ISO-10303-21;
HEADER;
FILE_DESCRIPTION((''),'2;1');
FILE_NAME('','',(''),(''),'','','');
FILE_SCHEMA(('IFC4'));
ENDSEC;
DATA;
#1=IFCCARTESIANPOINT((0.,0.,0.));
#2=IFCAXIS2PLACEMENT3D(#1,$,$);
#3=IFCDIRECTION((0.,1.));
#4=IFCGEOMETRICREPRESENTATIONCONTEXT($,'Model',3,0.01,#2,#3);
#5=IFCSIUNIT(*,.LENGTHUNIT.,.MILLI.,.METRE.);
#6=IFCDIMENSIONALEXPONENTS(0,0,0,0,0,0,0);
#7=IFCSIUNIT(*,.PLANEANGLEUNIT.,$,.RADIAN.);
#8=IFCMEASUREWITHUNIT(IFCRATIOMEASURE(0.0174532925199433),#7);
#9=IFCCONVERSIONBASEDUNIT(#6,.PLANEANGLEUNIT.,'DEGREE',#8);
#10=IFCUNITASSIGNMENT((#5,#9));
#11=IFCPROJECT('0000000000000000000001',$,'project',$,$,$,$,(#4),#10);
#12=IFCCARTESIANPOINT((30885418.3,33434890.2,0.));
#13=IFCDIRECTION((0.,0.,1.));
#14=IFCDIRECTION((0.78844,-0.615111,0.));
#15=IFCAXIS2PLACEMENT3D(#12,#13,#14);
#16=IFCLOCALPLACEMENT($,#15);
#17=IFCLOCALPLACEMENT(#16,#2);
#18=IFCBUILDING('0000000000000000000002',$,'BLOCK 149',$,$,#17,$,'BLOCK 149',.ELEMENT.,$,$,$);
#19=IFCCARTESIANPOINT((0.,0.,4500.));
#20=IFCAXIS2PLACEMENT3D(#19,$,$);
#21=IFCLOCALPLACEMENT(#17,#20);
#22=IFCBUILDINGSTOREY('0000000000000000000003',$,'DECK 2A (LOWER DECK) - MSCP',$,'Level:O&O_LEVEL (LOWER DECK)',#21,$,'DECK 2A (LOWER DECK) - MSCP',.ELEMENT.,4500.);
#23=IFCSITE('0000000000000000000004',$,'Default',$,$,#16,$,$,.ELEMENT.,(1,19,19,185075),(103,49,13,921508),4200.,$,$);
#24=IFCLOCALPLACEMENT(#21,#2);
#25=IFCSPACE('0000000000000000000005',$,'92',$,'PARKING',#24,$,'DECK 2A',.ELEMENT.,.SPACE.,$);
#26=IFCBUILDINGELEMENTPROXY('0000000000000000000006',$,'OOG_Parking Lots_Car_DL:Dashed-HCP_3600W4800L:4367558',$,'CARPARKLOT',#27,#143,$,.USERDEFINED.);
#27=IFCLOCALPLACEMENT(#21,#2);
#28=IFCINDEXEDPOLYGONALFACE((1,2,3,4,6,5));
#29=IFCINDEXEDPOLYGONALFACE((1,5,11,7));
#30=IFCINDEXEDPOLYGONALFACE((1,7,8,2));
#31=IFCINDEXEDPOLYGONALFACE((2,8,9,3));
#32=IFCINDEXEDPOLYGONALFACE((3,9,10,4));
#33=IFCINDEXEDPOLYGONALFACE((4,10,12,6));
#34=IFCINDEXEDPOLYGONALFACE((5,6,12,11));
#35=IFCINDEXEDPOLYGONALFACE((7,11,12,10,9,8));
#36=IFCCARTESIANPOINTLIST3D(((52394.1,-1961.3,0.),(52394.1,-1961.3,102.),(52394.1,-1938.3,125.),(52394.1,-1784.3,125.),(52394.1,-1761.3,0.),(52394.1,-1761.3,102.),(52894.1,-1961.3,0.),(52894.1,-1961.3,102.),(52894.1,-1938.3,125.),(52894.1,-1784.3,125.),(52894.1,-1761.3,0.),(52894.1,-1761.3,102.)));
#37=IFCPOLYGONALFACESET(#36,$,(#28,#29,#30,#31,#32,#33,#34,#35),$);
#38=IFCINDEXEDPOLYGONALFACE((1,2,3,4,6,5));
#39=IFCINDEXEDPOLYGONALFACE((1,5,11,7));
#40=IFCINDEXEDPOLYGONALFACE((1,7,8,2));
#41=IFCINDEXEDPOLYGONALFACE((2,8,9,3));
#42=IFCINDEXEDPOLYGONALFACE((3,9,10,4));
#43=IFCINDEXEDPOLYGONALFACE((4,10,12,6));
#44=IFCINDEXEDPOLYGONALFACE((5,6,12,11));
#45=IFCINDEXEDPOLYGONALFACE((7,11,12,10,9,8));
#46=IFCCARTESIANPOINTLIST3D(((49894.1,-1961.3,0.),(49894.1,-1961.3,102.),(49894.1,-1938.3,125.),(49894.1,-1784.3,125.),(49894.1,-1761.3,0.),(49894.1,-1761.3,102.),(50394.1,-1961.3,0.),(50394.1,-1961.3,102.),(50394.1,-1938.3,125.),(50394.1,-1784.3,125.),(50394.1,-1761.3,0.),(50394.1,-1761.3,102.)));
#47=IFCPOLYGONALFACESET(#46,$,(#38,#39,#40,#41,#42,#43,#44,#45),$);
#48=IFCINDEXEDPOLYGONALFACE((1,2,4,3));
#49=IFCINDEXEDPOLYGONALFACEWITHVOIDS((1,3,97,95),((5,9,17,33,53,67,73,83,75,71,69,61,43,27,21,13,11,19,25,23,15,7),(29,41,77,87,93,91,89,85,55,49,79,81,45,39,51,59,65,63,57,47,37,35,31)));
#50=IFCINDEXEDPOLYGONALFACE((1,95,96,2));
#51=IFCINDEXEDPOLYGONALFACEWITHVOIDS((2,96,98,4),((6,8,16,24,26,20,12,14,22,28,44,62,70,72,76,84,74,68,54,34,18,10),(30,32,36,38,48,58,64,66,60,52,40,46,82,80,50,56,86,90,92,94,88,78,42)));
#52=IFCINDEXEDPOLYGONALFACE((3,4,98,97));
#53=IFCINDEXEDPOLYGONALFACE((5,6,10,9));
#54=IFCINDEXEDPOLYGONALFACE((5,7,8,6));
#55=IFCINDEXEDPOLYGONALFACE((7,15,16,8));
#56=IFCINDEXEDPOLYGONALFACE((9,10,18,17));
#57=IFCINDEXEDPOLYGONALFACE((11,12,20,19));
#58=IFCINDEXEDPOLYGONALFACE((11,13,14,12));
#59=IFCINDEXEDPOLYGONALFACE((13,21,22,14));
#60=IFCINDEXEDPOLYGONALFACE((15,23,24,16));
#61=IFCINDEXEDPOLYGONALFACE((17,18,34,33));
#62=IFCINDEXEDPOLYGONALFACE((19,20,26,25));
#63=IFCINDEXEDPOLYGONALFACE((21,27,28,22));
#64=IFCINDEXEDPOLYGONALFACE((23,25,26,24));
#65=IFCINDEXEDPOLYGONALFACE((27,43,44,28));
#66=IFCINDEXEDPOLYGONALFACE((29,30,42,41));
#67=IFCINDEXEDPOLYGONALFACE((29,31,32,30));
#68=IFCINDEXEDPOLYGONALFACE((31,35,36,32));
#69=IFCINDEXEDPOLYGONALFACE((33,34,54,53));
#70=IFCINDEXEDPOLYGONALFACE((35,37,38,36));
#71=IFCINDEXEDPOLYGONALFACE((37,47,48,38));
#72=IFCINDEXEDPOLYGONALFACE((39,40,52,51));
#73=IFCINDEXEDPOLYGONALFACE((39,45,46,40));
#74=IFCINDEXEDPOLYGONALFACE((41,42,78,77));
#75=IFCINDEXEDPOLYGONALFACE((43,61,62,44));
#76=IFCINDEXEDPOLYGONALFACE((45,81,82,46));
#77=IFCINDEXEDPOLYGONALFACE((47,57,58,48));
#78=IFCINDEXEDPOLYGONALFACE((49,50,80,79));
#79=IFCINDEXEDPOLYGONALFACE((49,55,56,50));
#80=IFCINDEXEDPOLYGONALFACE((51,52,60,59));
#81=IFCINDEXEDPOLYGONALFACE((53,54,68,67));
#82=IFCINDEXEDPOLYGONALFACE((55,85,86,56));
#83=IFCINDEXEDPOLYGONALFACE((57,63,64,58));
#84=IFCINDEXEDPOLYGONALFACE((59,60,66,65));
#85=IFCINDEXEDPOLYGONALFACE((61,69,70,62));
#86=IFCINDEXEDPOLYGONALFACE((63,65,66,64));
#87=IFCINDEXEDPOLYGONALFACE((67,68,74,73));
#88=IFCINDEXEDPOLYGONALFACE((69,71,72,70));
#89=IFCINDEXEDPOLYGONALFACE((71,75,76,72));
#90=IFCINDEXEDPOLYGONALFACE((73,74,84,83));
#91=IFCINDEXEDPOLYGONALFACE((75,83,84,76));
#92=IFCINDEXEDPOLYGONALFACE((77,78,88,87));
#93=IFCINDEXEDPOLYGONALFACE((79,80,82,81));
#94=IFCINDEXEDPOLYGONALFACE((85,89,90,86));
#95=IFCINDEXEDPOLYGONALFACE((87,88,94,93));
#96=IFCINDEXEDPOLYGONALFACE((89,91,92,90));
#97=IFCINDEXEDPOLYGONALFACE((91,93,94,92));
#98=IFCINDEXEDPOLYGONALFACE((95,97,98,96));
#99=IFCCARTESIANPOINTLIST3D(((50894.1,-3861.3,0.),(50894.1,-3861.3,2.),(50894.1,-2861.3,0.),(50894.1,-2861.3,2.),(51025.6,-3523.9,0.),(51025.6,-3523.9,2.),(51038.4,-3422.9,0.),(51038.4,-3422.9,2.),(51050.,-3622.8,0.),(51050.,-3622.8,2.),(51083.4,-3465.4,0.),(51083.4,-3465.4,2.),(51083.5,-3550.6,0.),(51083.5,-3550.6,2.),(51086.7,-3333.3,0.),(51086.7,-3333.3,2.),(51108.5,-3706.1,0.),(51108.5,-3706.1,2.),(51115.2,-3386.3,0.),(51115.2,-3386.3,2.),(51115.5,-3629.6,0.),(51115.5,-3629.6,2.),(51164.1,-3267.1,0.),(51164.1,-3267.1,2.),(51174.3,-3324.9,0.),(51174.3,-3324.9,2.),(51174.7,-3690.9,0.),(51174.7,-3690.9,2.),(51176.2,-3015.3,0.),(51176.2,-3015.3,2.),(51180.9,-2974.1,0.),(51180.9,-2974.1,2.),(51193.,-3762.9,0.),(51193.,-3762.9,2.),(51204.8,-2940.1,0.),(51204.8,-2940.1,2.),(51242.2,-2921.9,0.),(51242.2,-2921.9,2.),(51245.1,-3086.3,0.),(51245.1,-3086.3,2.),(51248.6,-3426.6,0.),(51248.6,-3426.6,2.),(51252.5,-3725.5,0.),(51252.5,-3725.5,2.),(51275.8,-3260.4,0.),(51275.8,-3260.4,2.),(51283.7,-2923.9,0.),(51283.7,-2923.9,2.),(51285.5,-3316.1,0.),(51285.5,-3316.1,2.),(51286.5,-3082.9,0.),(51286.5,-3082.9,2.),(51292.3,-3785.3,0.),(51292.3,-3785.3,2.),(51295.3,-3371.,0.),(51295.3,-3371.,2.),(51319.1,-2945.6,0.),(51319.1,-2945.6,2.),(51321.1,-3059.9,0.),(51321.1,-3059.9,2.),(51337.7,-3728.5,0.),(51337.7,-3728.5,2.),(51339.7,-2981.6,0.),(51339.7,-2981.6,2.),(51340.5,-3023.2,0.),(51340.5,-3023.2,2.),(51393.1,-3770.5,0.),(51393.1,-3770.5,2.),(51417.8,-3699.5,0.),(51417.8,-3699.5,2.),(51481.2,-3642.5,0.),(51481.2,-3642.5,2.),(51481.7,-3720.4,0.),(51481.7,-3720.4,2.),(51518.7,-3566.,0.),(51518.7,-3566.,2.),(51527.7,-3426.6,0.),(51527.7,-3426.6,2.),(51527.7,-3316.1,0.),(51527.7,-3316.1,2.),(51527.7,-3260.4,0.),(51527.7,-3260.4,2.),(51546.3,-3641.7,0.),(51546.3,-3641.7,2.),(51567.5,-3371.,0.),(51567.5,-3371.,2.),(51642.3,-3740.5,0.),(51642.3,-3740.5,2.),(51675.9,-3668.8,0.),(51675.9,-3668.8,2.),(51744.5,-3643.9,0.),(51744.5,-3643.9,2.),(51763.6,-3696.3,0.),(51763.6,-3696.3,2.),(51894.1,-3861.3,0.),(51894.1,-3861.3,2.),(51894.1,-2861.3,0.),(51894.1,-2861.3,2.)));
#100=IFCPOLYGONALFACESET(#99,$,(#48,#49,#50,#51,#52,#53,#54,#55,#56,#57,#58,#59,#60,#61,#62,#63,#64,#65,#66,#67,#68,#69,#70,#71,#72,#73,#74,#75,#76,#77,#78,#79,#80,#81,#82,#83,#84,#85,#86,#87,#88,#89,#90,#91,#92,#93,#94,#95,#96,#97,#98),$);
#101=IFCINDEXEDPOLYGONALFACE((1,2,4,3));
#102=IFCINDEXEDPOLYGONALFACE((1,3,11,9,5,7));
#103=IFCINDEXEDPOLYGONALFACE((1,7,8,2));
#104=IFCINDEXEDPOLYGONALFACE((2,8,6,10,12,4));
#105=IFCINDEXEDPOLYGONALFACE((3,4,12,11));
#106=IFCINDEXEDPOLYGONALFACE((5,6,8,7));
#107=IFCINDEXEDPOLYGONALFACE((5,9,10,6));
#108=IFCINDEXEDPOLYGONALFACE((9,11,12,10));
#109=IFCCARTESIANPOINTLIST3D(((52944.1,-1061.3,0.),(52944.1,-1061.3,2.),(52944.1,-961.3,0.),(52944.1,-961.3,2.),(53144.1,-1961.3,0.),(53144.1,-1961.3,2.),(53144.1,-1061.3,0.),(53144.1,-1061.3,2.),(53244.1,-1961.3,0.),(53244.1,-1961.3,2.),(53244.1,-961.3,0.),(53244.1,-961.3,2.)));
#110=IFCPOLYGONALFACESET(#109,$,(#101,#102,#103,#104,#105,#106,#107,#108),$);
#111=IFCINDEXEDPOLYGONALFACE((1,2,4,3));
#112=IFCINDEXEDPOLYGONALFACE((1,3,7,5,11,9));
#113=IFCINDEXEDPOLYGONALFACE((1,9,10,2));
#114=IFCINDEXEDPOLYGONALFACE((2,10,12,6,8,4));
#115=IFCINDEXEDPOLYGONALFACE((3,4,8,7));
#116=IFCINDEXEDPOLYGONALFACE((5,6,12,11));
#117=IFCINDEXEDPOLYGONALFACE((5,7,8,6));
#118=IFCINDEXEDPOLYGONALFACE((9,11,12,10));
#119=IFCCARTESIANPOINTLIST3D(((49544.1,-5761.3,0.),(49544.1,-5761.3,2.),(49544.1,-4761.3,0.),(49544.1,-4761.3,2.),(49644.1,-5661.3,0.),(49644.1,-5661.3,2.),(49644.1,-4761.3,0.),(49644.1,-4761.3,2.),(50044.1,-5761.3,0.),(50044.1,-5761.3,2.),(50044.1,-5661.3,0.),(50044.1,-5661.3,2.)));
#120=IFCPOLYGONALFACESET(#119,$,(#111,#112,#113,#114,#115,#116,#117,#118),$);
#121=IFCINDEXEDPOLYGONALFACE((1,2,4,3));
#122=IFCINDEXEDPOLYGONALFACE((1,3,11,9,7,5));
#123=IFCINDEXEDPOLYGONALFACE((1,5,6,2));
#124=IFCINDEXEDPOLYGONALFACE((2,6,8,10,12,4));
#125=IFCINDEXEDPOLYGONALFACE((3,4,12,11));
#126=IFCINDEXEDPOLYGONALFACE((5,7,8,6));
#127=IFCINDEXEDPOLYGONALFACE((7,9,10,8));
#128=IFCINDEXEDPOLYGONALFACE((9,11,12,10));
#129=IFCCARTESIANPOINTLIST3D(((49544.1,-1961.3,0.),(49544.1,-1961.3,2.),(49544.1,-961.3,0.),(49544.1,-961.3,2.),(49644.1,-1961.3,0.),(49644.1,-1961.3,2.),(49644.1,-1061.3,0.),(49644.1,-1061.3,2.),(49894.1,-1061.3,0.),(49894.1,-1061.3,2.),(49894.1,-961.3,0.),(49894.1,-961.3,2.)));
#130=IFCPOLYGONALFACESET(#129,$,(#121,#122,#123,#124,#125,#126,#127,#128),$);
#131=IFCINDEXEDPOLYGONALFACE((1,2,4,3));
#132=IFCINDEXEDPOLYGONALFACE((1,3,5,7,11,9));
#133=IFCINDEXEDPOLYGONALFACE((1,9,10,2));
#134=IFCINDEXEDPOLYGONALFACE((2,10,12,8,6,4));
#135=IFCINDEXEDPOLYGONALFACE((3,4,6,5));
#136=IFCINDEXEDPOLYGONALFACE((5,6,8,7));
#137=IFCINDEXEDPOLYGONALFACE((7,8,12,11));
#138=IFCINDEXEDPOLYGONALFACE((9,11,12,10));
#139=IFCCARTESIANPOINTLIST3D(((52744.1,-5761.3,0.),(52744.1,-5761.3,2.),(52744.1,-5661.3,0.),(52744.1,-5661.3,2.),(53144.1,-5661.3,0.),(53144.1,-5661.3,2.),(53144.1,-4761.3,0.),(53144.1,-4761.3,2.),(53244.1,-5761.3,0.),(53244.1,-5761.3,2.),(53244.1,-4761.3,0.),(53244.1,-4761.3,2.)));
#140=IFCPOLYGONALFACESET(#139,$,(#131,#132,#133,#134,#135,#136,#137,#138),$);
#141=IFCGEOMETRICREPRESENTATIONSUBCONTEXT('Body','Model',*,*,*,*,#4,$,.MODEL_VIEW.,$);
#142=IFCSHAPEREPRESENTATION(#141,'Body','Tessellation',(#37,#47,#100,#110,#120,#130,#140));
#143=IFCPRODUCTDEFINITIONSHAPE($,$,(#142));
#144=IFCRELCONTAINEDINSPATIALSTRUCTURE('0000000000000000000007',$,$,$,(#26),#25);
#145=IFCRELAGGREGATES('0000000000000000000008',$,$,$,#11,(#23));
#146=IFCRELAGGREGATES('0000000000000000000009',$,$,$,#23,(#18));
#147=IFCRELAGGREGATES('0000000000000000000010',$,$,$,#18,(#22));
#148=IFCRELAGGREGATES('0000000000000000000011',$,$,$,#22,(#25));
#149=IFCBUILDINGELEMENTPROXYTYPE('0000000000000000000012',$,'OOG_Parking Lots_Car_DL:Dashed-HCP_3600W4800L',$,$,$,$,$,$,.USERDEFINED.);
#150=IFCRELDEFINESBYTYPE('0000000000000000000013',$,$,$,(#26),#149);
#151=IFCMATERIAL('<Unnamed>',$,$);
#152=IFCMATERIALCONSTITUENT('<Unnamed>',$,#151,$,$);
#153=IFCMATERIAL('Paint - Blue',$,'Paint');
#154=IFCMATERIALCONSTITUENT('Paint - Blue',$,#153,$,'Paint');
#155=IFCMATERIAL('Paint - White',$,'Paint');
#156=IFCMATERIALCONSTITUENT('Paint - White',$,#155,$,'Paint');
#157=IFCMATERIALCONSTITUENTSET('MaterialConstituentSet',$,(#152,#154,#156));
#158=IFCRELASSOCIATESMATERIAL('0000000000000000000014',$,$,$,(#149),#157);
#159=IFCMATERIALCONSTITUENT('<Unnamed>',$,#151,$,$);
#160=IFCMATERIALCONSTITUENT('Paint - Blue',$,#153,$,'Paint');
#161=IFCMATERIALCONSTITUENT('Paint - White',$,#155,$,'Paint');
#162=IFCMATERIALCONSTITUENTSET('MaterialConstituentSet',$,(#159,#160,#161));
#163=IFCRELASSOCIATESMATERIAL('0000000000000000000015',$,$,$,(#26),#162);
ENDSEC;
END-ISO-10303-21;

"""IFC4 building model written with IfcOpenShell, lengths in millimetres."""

from ifc_helpers import new_model, entity, si_unit, converted_unit, direction, frame, origin, place, context, subcontext, project, spatial, indexed_curve, outline, extrude, source, transform, mapped, material, constituent, constituent_set, type_object, type_shapes, element, save


model = new_model("IFC4")

# Units and contexts
model_context = context("Model", 3, precision=0.01, world=origin(), true_north=direction((0.0, 1.0)))
body_context = subcontext(model_context, "Body", "Model", "MODEL_VIEW")
ifc_project = project(units=[si_unit("LENGTHUNIT", "METRE", prefix="MILLI"), converted_unit("PLANEANGLEUNIT", "DEGREE", entity("IfcRatioMeasure", 0.0174532925199433), si_unit("PLANEANGLEUNIT", "RADIAN"), dimensions=[0, 0, 0, 0, 0, 0, 0])], contexts=[model_context])

# Site, building, storey
site_placement = place(None, frame((30885418.3, 33434890.2, 0.0), z_axis=(0.0, 0.0, 1.0), x_axis=(0.78844, -0.615111, 0.0)))
site = spatial("IfcSite", under=ifc_project, at=site_placement, Name="Default", CompositionType="ELEMENT", RefLatitude=(1, 19, 19, 185075), RefLongitude=(103, 49, 13, 921508), RefElevation=4200.0)
building_placement = place(site_placement, origin())
building = spatial("IfcBuilding", under=site, at=building_placement, Name="BLOCK 149", LongName="BLOCK 149", CompositionType="ELEMENT")
storey_placement = place(building_placement, frame((0.0, 0.0, 4500.0)))
storey = spatial("IfcBuildingStorey", under=building, at=storey_placement, Name="DECK 2A (LOWER DECK) - MSCP", ObjectType="Level:O&O_LEVEL (LOWER DECK)", LongName="DECK 2A (LOWER DECK) - MSCP", CompositionType="ELEMENT", Elevation=4500.0)

# Shared definitions
ifc_material_1 = material(Name="<Unnamed>")

# Shared definitions
space_placement = place(storey_placement, origin())
space = spatial("IfcSpace", under=storey, at=space_placement, Name="92", ObjectType="PARKING", LongName="DECK 2A", CompositionType="ELEMENT", PredefinedType="SPACE")

# Building element proxy
ifc_material_2 = material(Name="Paint - White", Category="Paint")
ifc_material_3 = material(Name="Paint - Blue", Category="Paint")
ifc_constituent_1 = constituent(ifc_material_1, Name="<Unnamed>")
ifc_constituent_2 = constituent(ifc_material_3, Name="Paint - Blue", Category="Paint")
ifc_constituent_3 = constituent(ifc_material_2, Name="Paint - White", Category="Paint")
ifc_constituent_set_1 = constituent_set(constituents=[ifc_constituent_1, ifc_constituent_2, ifc_constituent_3], Name="MaterialConstituentSet")
ifc_constituent_4 = constituent(ifc_material_1, Name="<Unnamed>")
ifc_constituent_5 = constituent(ifc_material_3, Name="Paint - Blue", Category="Paint")
ifc_constituent_6 = constituent(ifc_material_2, Name="Paint - White", Category="Paint")
ifc_constituent_set_2 = constituent_set(constituents=[ifc_constituent_4, ifc_constituent_5, ifc_constituent_6], Name="MaterialConstituentSet")
building_element_proxy_type_1 = type_object("IfcBuildingElementProxyType", Name="OOG_Parking Lots_Car_DL:Dashed-HCP_3600W4800L", PredefinedType="USERDEFINED", material=ifc_constituent_set_2)
shared_shape_1 = source(origin(), body_context, "Body", "SweptSolid", [
    extrude(outline(indexed_curve([(-100.0, -75.7), (100.0, -75.7), (100.0, 26.3), (77.0, 49.3), (-77.0, 49.3), (-100.0, 26.3), (-100.0, -75.7)], self_intersect=False)), frame((2800.0, -850.0, 75.7), z_axis=(1.0, 0.0, 0.0), x_axis=(0.0, 1.0, 0.0)), (0.0, 0.0, 1.0), 500.0),
    extrude(outline(indexed_curve([(-100.0, -75.7), (100.0, -75.7), (100.0, 26.3), (77.0, 49.3), (-77.0, 49.3), (-100.0, 26.3), (-100.0, -75.7)], self_intersect=False)), frame((300.0, -850.0, 75.7), z_axis=(1.0, 0.0, 0.0), x_axis=(0.0, 1.0, 0.0)), (0.0, 0.0, 1.0), 500.0),
    extrude(outline(indexed_curve([(-500.0, -500.0), (500.0, -500.0), (500.0, 500.0), (-500.0, 500.0), (-500.0, -500.0)], self_intersect=False), holes=[indexed_curve([(149.0, -274.9), (118.4, -100.9), (-133.6, -100.9), (-133.6, -45.2), (108.6, -45.2), (98.8, 9.7), (-173.4, 9.7), (-281.8, 307.5), (-350.4, 282.6), (-369.5, 335.1), (-248.2, 379.2), (-133.6, 65.3), (145.5, 65.3), (218.0, -346.0), (213.3, -387.2), (189.3, -421.2), (152.0, -439.4), (110.5, -437.4), (75.1, -415.7), (54.4, -379.7), (53.7, -338.1), (73.0, -301.3), (107.6, -278.4), (149.0, -274.9)], self_intersect=False), indexed_curve([(-124.5, 204.7), (-152.1, 280.4), (-87.5, 359.1), (1.1, 409.2), (101.8, 424.0), (201.1, 401.6), (285.7, 344.9), (344.1, 261.5), (368.6, 162.6), (355.8, 61.6), (307.4, -28.0), (230.0, -94.2), (219.8, -36.4), (278.9, 25.0), (310.7, 104.1), (310.6, 189.3), (278.7, 268.3), (219.4, 329.6), (141.6, 364.2), (56.5, 367.3), (-23.6, 338.2), (-87.0, 281.3), (-124.5, 204.7)], self_intersect=False)]), frame((1800.0, -2350.0, 0.0), z_axis=(0.0, 0.0, 1.0), x_axis=(-1.0, 0.0, 0.0)), (0.0, 0.0, 1.0), 2.0),
    extrude(outline(indexed_curve([(-633.3, -133.3), (366.7, -133.3), (366.7, 166.7), (266.7, 166.7), (266.7, -33.3), (-633.3, -33.3), (-633.3, -133.3)], self_intersect=False)), frame((3516.7, -316.7, 0.0), z_axis=(0.0, 0.0, 1.0), x_axis=(0.0, 1.0, 0.0)), (0.0, 0.0, 1.0), 2.0),
    extrude(outline(indexed_curve([(-633.3, -200.0), (366.7, -200.0), (366.7, 300.0), (266.7, 300.0), (266.7, -100.0), (-633.3, -100.0), (-633.3, -200.0)], self_intersect=False)), frame((150.0, -4383.3, 0.0), z_axis=(0.0, 0.0, 1.0), x_axis=(0.0, -1.0, 0.0)), (0.0, 0.0, 1.0), 2.0),
    extrude(outline(indexed_curve([(-200.0, -366.7), (150.0, -366.7), (150.0, 633.3), (50.0, 633.3), (50.0, -266.7), (-200.0, -266.7), (-200.0, -366.7)], self_intersect=False)), frame((100.0, -316.7, 0.0), z_axis=(0.0, 0.0, 1.0), x_axis=(-1.0, 0.0, 0.0)), (0.0, 0.0, 1.0), 2.0),
    extrude(outline(indexed_curve([(-300.0, -366.7), (200.0, -366.7), (200.0, 633.3), (100.0, 633.3), (100.0, -266.7), (-300.0, -266.7), (-300.0, -366.7)], self_intersect=False)), frame((3450.0, -4383.3, 0.0)), (0.0, 0.0, 1.0), 2.0),
])
type_shapes(building_element_proxy_type_1, [shared_shape_1])
proxy_1_placement = place(space_placement, frame((49594.1, -1011.3, 0.0)))
element("IfcBuildingElementProxy", 1, at=proxy_1_placement, inside=space, type_object=building_element_proxy_type_1, material=ifc_constituent_set_1, Name="OOG_Parking Lots_Car_DL:Dashed-HCP_3600W4800L:4367558", ObjectType="CARPARKLOT", PredefinedType="USERDEFINED", context=body_context, shape_type="MappedRepresentation", body=[
    mapped(shared_shape_1, transform((0.0, 0.0, 0.0), scale=1.0)),
])

save(model, "model.ifc")
